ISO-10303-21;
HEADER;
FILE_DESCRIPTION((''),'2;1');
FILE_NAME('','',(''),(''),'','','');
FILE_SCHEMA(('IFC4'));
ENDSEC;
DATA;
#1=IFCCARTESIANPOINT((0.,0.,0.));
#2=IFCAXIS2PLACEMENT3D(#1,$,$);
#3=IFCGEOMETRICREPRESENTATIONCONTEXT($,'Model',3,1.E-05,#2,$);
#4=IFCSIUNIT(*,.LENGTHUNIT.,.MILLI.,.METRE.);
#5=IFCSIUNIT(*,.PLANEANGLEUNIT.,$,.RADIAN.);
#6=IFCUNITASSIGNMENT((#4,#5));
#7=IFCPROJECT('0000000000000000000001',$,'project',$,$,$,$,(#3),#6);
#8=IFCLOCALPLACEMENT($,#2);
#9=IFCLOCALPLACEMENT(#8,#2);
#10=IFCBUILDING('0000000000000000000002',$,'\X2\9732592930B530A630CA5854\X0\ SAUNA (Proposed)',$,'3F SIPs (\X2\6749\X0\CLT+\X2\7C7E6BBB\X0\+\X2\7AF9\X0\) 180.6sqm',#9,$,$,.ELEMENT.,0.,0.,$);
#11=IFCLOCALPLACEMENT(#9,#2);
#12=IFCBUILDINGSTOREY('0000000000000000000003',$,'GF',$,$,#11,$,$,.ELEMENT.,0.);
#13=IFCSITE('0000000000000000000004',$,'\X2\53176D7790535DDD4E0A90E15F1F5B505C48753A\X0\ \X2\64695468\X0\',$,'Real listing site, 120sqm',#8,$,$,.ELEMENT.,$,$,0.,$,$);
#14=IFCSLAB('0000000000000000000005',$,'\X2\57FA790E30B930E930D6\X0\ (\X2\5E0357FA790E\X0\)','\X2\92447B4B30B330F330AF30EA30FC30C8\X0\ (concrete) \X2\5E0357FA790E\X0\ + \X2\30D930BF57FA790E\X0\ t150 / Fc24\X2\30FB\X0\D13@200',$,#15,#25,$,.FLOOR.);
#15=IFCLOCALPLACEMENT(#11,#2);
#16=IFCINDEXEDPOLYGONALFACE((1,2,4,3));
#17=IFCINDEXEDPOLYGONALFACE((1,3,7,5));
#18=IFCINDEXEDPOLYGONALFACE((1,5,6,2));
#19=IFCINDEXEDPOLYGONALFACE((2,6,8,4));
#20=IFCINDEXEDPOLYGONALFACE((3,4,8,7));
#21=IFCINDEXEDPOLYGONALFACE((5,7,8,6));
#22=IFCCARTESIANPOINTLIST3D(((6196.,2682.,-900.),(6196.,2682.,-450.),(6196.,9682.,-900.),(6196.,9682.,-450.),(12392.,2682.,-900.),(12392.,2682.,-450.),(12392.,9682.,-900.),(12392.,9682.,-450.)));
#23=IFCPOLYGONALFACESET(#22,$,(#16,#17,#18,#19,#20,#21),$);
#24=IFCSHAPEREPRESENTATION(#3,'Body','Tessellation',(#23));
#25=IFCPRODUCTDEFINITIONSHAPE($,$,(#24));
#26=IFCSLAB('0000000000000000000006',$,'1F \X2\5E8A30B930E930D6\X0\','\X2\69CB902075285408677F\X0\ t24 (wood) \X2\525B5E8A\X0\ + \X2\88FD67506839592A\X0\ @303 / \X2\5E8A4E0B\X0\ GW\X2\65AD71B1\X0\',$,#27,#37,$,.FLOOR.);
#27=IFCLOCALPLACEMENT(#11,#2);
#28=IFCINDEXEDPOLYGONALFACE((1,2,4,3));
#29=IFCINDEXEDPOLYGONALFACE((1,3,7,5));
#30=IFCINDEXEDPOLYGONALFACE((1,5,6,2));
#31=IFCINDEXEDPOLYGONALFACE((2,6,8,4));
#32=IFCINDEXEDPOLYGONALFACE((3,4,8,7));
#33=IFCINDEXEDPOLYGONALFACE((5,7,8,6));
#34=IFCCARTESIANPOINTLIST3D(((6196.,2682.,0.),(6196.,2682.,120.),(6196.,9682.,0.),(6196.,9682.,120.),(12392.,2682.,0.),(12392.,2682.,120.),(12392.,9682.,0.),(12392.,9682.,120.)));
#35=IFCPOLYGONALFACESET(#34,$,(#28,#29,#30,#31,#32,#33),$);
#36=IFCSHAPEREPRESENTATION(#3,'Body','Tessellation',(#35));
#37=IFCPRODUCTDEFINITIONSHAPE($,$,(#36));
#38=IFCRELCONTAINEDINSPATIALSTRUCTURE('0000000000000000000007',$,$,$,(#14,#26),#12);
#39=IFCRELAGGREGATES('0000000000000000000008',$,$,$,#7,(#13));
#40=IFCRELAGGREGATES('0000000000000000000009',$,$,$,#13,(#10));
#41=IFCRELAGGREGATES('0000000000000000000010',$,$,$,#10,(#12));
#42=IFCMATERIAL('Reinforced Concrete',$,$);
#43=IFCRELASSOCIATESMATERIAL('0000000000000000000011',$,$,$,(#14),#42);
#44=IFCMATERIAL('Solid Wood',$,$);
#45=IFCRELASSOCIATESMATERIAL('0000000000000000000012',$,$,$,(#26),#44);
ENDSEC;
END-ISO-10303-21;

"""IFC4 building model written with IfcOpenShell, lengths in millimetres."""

from ifc_helpers import new_model, si_unit, frame, frame_2d, origin, place, context, project, spatial, rectangle, extrude, material, element, save


model = new_model("IFC4")

# Units and contexts
model_context = context("Model", 3, precision=1e-05, world=origin())
ifc_project = project(units=[si_unit("LENGTHUNIT", "METRE", prefix="MILLI"), si_unit("PLANEANGLEUNIT", "RADIAN")], contexts=[model_context])

# Site, building, storey
site_placement = place(None, origin())
site = spatial("IfcSite", under=ifc_project, at=site_placement, Name="北海道川上郡弟子屈町 摩周", ObjectType="Real listing site, 120sqm", CompositionType="ELEMENT", RefElevation=0.0)
building_placement = place(site_placement, origin())
building = spatial("IfcBuilding", under=site, at=building_placement, Name="露天サウナ塔 SAUNA (Proposed)", ObjectType="3F SIPs (杉CLT+籾殻+竹) 180.6sqm", CompositionType="ELEMENT", ElevationOfRefHeight=0.0, ElevationOfTerrain=0.0)
storey_placement = place(building_placement, origin())
storey = spatial("IfcBuildingStorey", under=building, at=storey_placement, Name="GF", CompositionType="ELEMENT", Elevation=0.0)

# Slabs
ifc_material_1 = material(Name="Reinforced Concrete")
slab_1_placement = place(storey_placement, frame((3098.0, 1341.0, -450.0)))
element("IfcSlab", 1, at=slab_1_placement, inside=storey, material=ifc_material_1, Name="基礎スラブ (布基礎)", Description="鉄筋コンクリート (concrete) 布基礎 + ベタ基礎 t150 / Fc24・D13@200", PredefinedType="FLOOR", context=model_context, shape_type="SweptSolid", body=[
    extrude(rectangle(XDim=6196.0, YDim=7000.0, at=frame_2d((3098.0, 3500.0))), frame((3098.0, 1341.0, -450.0)), (0.0, 0.0, 1.0), 450.0),
])
ifc_material_2 = material(Name="Solid Wood")
slab_2_placement = place(storey_placement, frame((3098.0, 1341.0, 0.0)))
element("IfcSlab", 2, at=slab_2_placement, inside=storey, material=ifc_material_2, Name="1F 床スラブ", Description="構造用合板 t24 (wood) 剛床 + 製材根太 @303 / 床下 GW断熱", PredefinedType="FLOOR", context=model_context, shape_type="SweptSolid", body=[
    extrude(rectangle(XDim=6196.0, YDim=7000.0, at=frame_2d((3098.0, 3500.0))), frame((3098.0, 1341.0, 0.0)), (0.0, 0.0, 1.0), 120.0),
])

save(model, "model.ifc")
